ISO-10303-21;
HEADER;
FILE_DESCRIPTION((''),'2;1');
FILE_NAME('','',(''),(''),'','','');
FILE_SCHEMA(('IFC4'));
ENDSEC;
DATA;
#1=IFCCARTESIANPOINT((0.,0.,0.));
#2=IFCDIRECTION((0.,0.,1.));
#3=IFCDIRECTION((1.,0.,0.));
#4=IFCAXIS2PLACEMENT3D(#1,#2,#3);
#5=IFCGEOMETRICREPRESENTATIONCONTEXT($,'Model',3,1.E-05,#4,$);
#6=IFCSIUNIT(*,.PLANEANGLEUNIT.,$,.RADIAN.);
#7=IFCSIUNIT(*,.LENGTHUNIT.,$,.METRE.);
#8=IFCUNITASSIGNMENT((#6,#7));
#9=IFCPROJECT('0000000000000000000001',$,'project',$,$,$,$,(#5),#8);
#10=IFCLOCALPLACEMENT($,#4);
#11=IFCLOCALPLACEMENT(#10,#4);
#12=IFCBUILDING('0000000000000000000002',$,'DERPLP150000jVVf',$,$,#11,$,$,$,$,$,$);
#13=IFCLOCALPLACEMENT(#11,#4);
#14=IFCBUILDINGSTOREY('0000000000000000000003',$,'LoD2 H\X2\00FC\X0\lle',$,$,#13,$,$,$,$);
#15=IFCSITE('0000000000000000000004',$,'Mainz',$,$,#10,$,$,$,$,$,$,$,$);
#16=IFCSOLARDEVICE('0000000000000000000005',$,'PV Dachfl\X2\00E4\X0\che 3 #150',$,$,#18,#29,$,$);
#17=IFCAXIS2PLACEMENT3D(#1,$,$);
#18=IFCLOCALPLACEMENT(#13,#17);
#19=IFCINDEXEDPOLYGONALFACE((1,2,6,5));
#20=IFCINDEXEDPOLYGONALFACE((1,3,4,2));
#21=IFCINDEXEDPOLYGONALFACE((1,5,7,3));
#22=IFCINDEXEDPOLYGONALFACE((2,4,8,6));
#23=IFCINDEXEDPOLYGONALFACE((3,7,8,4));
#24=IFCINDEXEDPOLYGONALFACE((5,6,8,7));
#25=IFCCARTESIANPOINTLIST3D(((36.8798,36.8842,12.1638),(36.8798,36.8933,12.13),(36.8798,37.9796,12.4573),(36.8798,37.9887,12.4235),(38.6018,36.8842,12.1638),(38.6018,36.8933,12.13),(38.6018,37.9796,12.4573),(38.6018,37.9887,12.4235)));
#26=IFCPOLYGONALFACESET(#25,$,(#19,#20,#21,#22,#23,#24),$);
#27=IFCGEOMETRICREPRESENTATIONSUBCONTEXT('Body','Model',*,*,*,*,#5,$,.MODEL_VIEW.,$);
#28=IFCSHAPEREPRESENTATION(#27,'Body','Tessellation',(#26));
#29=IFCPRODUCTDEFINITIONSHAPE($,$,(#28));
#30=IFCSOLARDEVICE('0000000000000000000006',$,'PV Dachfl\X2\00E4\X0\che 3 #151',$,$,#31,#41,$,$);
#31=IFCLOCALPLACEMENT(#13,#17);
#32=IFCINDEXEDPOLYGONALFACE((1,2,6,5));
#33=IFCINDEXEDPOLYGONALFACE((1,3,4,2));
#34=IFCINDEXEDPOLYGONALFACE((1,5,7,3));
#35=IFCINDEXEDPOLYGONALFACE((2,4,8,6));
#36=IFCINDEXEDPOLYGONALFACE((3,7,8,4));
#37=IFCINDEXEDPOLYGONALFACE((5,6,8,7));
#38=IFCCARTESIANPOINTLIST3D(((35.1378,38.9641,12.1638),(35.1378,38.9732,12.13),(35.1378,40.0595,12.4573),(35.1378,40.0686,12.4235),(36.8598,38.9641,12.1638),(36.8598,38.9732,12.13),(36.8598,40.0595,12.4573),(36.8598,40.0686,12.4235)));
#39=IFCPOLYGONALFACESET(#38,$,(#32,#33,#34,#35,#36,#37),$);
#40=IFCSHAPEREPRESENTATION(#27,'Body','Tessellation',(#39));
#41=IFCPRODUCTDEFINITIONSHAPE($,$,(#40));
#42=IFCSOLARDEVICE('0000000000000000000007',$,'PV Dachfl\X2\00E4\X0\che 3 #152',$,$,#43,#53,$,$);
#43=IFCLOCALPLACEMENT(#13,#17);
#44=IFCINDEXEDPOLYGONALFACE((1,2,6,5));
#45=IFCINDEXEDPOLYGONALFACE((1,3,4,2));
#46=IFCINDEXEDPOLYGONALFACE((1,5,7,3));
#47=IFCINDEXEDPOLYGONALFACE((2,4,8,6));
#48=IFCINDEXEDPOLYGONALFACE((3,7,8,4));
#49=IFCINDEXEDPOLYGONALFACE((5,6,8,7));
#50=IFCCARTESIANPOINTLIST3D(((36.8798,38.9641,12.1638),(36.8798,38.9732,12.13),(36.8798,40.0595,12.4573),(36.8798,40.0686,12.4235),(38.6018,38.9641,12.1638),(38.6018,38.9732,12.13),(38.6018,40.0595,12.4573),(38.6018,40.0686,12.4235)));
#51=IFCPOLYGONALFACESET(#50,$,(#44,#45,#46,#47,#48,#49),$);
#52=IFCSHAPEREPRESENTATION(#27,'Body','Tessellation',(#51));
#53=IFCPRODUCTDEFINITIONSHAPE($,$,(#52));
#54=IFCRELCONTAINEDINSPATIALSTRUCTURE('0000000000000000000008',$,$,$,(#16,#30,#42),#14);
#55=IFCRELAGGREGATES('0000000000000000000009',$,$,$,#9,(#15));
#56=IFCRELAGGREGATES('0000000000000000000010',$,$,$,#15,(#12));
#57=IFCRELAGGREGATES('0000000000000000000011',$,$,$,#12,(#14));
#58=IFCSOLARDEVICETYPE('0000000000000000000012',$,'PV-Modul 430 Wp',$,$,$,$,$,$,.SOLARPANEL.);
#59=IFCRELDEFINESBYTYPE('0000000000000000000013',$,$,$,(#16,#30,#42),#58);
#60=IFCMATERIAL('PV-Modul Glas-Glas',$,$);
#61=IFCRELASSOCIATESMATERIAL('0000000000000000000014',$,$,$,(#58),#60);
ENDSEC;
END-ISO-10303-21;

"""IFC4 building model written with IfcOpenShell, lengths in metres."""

from ifc_helpers import new_model, si_unit, frame, frame_2d, origin, origin_with_axes, place, context, subcontext, project, spatial, rectangle, extrude, source, transform, mapped, material, type_object, type_shapes, element, save


model = new_model("IFC4")

# Units and contexts
model_context = context("Model", 3, precision=1e-05, world=origin_with_axes())
body_context = subcontext(model_context, "Body", "Model", "MODEL_VIEW")
ifc_project = project(units=[si_unit("PLANEANGLEUNIT", "RADIAN"), si_unit("LENGTHUNIT", "METRE")], contexts=[model_context])

# Site, building, storey
site_placement = place(None, origin_with_axes())
site = spatial("IfcSite", under=ifc_project, at=site_placement, Name="Mainz")
building_placement = place(site_placement, origin_with_axes())
building = spatial("IfcBuilding", under=site, at=building_placement, Name="DERPLP150000jVVf")
storey_placement = place(building_placement, origin_with_axes())
storey = spatial("IfcBuildingStorey", under=building, at=storey_placement, Name="LoD2 Hülle")

# Solar devices
ifc_material = material(Name="PV-Modul Glas-Glas")
solar_device_type = type_object("IfcSolarDeviceType", Name="PV-Modul 430 Wp", PredefinedType="SOLARPANEL", material=ifc_material)
shared_shape = source(origin_with_axes(), body_context, "Body", "SweptSolid", [
    extrude(rectangle(XDim=1.722, YDim=1.134, at=frame_2d((0.861, 0.567))), origin(), (0.0, 0.0, 1.0), 0.035),
])
type_shapes(solar_device_type, [shared_shape])
for number, where, z_axis, x_axis, name in (
    (1, (36.8798, 36.8933, 12.13), (0.0, -0.258819, 0.965926), (1.0, 0.0, 0.0), "PV Dachfläche 3 #150"),
    (2, (35.1378, 38.9732, 12.13), (0.0, -0.258819, 0.965926), (1.0, 0.0, 0.0), "PV Dachfläche 3 #151"),
    (3, (36.8798, 38.9732, 12.13), (0.0, -0.258819, 0.965926), (1.0, 0.0, 0.0), "PV Dachfläche 3 #152"),
):
    element("IfcSolarDevice", number, at=place(storey_placement, frame(where, z_axis=z_axis, x_axis=x_axis)), inside=storey, type_object=solar_device_type, Name=name, context=body_context, shape_type="MappedRepresentation", body=[
        mapped(shared_shape, transform((0.0, 0.0, 0.0), x_axis=(1.0, 0.0, 0.0), y_axis=(0.0, 1.0, 0.0), z_axis=(0.0, 0.0, 1.0), scale=1.0)),
    ])

save(model, "model.ifc")
